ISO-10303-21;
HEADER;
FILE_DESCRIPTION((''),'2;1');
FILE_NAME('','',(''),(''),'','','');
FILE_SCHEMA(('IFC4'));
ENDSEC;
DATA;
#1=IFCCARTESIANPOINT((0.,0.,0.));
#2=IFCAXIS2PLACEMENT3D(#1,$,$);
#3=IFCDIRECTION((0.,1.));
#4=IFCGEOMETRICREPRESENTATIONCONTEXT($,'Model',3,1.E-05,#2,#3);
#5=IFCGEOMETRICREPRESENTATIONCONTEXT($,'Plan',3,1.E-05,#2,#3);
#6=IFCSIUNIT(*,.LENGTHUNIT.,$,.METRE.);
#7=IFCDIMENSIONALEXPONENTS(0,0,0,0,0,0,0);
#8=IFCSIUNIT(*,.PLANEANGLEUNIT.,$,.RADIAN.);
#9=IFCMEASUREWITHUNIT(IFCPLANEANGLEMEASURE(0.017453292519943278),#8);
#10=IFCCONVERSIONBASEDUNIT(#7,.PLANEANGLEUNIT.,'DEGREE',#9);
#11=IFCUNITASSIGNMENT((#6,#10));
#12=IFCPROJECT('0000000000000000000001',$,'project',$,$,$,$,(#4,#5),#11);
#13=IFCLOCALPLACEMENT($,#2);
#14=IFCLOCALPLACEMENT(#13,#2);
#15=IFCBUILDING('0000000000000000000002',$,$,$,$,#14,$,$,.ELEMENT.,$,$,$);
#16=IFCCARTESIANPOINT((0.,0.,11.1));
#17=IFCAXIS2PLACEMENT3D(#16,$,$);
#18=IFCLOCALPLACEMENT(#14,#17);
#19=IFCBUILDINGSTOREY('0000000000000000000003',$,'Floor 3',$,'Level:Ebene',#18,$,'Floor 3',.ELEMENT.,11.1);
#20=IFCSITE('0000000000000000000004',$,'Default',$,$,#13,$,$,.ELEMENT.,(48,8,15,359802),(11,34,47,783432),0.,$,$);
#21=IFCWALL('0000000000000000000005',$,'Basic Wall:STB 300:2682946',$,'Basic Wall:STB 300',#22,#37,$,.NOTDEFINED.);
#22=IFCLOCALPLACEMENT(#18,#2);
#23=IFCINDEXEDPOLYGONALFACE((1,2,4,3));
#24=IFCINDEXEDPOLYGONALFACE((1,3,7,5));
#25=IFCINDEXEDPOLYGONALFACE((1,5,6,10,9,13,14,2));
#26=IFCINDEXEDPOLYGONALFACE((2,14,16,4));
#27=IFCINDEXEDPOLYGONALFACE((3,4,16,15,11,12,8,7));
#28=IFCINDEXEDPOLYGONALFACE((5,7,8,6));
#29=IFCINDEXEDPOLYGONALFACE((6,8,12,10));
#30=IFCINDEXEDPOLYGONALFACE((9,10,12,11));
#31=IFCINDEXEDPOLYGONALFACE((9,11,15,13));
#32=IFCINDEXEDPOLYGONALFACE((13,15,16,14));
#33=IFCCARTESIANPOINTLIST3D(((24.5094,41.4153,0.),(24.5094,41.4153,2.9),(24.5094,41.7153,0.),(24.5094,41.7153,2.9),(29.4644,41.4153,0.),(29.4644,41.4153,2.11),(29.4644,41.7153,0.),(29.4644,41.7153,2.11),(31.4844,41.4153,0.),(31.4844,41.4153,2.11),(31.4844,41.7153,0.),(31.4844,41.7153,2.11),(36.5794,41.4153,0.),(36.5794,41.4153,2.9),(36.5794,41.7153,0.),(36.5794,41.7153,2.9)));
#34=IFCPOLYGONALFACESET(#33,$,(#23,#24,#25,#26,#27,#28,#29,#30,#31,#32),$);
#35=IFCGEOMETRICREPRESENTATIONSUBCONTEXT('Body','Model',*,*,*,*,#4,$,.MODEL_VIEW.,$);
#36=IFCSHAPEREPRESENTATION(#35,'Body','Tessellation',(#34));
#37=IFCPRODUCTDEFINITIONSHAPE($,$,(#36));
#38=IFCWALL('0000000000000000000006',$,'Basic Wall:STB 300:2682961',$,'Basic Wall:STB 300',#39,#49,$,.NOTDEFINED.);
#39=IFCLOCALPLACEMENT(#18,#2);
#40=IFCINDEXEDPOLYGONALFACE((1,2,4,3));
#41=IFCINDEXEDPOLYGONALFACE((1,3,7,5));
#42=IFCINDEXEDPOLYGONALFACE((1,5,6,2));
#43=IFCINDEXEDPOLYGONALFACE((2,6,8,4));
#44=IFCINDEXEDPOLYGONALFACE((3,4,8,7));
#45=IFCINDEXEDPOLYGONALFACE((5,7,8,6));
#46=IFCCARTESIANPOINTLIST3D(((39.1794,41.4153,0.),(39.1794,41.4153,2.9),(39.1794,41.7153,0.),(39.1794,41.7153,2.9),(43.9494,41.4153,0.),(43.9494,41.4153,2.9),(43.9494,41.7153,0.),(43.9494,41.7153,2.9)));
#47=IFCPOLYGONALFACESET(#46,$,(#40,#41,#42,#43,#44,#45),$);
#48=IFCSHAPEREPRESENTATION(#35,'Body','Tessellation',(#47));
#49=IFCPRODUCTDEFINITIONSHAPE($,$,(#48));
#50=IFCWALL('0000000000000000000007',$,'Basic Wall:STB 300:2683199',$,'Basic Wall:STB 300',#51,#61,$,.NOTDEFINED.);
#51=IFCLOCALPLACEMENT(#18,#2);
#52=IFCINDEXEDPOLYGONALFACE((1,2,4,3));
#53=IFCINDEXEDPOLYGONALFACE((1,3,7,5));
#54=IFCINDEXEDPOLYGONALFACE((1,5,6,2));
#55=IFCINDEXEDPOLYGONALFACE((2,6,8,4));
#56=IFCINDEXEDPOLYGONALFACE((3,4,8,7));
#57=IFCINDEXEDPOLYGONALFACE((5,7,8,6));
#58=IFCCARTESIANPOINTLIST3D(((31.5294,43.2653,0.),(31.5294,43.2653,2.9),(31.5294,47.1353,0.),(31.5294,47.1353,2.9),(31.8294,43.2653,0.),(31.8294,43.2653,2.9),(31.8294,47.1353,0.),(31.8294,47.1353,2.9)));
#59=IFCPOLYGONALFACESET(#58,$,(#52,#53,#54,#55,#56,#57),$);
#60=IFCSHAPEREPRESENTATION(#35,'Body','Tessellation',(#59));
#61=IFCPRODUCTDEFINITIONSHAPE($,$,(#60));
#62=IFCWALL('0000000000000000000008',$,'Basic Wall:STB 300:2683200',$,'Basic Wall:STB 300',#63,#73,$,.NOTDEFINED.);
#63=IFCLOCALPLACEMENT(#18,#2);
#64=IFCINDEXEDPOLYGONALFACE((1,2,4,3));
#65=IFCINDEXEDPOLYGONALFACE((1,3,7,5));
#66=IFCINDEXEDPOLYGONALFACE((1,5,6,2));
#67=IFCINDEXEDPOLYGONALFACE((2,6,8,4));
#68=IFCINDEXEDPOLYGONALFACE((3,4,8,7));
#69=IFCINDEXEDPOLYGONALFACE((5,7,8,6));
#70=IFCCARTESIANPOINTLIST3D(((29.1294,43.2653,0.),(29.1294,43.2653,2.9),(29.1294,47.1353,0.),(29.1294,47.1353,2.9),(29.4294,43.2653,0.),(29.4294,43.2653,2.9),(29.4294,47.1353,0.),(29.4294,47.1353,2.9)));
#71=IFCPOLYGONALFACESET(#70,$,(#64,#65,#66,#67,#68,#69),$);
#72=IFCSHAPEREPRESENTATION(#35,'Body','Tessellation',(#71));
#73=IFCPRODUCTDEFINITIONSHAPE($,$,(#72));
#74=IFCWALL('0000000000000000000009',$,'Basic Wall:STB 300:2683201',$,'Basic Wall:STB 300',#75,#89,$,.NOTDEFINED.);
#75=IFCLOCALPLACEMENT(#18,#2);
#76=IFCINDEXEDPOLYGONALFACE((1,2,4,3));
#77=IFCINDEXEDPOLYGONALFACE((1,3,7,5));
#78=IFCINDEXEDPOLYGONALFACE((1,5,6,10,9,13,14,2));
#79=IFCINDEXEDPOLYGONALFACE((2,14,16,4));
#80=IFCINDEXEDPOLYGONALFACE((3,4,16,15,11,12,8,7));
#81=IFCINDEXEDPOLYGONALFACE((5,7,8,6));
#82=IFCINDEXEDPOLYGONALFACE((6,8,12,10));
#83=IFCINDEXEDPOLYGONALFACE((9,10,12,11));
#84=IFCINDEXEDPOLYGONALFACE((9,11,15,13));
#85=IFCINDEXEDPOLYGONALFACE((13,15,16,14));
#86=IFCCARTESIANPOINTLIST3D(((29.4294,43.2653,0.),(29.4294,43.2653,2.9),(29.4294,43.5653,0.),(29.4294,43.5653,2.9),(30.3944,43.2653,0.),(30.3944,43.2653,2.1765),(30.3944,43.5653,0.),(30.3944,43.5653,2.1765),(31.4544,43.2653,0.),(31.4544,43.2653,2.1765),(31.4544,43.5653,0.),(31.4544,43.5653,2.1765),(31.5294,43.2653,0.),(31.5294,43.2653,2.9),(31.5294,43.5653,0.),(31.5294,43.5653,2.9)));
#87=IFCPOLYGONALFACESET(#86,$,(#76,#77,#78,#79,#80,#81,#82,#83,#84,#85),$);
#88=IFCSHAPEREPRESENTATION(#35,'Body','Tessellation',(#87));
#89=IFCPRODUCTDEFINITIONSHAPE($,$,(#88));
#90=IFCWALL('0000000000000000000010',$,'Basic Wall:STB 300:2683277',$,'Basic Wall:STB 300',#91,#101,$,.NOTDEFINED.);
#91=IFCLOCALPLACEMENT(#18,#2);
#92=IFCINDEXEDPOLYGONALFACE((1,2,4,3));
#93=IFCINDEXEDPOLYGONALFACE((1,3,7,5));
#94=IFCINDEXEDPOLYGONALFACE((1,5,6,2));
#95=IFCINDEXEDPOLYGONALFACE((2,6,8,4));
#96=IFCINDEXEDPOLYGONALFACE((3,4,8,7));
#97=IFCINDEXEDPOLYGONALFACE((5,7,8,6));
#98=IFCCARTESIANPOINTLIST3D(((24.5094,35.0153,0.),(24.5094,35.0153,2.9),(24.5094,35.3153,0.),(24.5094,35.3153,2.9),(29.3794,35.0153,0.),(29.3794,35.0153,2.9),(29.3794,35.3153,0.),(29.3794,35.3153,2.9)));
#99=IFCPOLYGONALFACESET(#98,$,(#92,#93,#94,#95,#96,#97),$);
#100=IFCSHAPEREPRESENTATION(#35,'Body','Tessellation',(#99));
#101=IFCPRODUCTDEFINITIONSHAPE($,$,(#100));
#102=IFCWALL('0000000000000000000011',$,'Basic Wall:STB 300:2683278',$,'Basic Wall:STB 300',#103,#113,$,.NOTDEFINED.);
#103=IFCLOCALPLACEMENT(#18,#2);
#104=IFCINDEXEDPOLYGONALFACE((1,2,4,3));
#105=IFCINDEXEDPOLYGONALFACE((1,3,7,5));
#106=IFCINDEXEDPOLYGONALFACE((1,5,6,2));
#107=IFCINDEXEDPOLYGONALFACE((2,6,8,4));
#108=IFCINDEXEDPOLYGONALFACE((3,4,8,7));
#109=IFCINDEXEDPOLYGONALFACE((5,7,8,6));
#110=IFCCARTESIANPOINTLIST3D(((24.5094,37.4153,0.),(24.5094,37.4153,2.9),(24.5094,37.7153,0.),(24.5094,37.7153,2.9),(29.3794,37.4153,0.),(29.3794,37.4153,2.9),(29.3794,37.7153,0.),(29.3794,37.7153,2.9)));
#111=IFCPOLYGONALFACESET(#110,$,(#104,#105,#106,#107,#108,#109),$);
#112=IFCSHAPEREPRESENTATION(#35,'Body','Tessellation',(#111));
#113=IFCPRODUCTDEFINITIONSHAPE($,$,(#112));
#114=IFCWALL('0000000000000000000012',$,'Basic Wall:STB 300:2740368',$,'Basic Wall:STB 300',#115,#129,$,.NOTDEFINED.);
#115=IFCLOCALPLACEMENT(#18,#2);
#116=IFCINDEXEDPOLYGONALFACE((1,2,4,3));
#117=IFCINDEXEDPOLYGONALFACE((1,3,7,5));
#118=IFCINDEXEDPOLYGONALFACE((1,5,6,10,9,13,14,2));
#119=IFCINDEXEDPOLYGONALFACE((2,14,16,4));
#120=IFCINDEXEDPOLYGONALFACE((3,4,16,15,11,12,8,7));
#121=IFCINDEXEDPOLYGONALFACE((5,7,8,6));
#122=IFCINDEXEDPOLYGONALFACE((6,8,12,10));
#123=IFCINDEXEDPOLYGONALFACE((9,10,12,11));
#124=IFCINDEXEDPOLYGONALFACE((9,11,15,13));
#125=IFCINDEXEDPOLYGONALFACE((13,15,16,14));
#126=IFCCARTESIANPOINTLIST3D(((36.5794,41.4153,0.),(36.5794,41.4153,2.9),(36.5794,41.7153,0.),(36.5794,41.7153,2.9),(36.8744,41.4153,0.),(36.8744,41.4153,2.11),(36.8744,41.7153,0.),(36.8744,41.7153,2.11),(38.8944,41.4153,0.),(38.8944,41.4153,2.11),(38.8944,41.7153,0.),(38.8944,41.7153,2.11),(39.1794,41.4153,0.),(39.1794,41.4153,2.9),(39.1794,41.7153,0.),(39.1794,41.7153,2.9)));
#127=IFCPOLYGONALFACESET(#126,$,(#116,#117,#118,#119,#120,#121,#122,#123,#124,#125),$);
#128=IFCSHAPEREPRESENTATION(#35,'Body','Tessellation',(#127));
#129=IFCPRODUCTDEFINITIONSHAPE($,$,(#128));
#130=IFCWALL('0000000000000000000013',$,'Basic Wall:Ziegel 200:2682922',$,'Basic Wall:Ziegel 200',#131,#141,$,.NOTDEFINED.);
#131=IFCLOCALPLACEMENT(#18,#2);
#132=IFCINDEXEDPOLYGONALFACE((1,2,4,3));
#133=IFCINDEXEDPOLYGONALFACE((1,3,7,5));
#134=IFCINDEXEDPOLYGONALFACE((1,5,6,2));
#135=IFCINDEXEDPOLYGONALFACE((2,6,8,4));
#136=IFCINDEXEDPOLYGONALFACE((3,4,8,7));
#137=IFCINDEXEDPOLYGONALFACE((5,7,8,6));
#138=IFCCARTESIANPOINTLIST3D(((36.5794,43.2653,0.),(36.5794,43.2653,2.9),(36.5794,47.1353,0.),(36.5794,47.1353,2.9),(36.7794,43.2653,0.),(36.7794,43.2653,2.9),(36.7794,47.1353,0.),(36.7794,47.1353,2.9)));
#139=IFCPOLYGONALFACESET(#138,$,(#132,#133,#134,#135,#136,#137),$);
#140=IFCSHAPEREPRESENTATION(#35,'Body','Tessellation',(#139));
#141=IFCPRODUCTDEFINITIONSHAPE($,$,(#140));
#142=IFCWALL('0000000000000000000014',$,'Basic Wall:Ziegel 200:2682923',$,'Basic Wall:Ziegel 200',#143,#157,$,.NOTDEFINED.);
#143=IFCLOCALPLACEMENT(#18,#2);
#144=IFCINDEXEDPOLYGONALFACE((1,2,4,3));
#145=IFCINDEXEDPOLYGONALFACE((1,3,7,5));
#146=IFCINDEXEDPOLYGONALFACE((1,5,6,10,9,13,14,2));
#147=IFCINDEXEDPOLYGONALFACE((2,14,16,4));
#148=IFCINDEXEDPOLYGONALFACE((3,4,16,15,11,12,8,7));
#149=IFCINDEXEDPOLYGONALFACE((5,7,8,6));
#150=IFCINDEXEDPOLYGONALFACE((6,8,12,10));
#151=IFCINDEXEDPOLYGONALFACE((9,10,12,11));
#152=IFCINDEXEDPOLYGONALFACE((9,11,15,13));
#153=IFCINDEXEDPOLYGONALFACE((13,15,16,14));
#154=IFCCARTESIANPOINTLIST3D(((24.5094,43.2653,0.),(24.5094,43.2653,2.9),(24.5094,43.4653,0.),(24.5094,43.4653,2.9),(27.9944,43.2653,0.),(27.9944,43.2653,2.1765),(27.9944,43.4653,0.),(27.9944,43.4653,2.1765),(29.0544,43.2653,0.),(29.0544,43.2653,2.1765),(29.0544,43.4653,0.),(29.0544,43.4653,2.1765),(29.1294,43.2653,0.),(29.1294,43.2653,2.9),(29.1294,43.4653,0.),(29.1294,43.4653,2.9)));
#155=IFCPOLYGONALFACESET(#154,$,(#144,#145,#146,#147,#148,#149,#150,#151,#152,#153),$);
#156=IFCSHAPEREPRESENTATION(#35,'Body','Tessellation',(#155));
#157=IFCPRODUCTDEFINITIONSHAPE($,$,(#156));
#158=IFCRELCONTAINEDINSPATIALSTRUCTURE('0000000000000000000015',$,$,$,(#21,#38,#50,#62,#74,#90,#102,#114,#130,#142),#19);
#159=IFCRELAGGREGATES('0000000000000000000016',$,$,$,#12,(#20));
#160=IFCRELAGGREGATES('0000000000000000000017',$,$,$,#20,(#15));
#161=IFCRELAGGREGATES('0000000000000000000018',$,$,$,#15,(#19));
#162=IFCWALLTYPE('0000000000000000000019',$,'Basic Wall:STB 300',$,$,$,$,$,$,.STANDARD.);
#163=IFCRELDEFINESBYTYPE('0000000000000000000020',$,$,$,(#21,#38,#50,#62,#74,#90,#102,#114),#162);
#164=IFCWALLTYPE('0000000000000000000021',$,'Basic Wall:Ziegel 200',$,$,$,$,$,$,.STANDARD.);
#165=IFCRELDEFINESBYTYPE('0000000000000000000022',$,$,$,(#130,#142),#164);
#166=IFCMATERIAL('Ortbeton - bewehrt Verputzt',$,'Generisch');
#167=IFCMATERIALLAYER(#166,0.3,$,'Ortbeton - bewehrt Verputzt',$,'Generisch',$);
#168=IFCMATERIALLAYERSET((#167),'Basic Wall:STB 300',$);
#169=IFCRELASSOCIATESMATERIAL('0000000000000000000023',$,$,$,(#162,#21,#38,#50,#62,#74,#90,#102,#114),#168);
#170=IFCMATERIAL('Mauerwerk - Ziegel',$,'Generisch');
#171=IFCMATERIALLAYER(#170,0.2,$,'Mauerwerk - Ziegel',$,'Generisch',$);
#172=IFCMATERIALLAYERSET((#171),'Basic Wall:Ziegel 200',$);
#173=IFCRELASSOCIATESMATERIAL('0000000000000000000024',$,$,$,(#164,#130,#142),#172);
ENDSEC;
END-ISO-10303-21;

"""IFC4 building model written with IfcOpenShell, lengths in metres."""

from ifc_helpers import new_model, entity, si_unit, converted_unit, direction, frame, frame_2d, origin, place, context, subcontext, project, spatial, rectangle, extrude, material, layer, layer_set, layer_usage, type_object, element, save


model = new_model("IFC4")

# Units and contexts
model_context = context("Model", 3, precision=1e-05, world=origin(), true_north=direction((0.0, 1.0)))
plan_context = context("Plan", 3, precision=1e-05, world=origin(), true_north=direction((0.0, 1.0)))
body_context = subcontext(model_context, "Body", "Model", "MODEL_VIEW")
ifc_project = project(units=[si_unit("LENGTHUNIT", "METRE"), converted_unit("PLANEANGLEUNIT", "DEGREE", entity("IfcPlaneAngleMeasure", 0.017453292519943278), si_unit("PLANEANGLEUNIT", "RADIAN"), dimensions=[0, 0, 0, 0, 0, 0, 0])], contexts=[model_context, plan_context])

# Site, building, storey
site_placement = place(None, origin())
site = spatial("IfcSite", under=ifc_project, at=site_placement, Name="Default", CompositionType="ELEMENT", RefLatitude=(48, 8, 15, 359802), RefLongitude=(11, 34, 47, 783432), RefElevation=0.0)
building_placement = place(site_placement, origin())
building = spatial("IfcBuilding", under=site, at=building_placement, CompositionType="ELEMENT")
storey_placement = place(building_placement, frame((0.0, 0.0, 11.1)))
storey = spatial("IfcBuildingStorey", under=building, at=storey_placement, Name="Floor 3", ObjectType="Level:Ebene", LongName="Floor 3", CompositionType="ELEMENT", Elevation=11.1)

# Wall, opening
ifc_material_1 = material(Name="Ortbeton - bewehrt Verputzt", Category="Generisch")
ifc_layer_1 = layer(ifc_material_1, 0.3, Name="Ortbeton - bewehrt Verputzt", Category="Generisch")
ifc_layer_set_1 = layer_set([ifc_layer_1], Name="Basic Wall:STB 300")
ifc_layer_usage_1 = layer_usage(ifc_layer_set_1, "AXIS2", "NEGATIVE", 0.15)
wall_type_1 = type_object("IfcWallType", Name="Basic Wall:STB 300", PredefinedType="STANDARD", material=ifc_layer_set_1)
wall_1_placement = place(storey_placement, frame((24.5094, 41.5653, 0.0)))
wall_1 = element("IfcWall", 1, at=wall_1_placement, inside=storey, type_object=wall_type_1, material=ifc_layer_usage_1, Name="Basic Wall:STB 300:2682946", ObjectType="Basic Wall:STB 300", PredefinedType="NOTDEFINED", context=body_context, shape_type="SweptSolid", body=[
    extrude(rectangle(XDim=12.07, YDim=0.3, at=frame_2d((6.035, 0.0), x_axis=(-1.0, 0.0))), origin(), (0.0, 0.0, 1.0), 2.9),
])
opening_1_placement = place(wall_1_placement, frame((6.975, 0.15, 0.0)))
element("IfcOpeningElement", 2, at=opening_1_placement, cuts=wall_1, PredefinedType="OPENING", context=body_context, shape_type="SweptSolid", body=[
    extrude(rectangle(XDim=2.11, YDim=2.02, at=frame_2d((1.055, 1.01), x_axis=(1.0, 0.0))), frame((0.0, 0.0, 0.0), z_axis=(0.0, -1.0, 0.0), x_axis=(0.0, 0.0, 1.0)), (0.0, 0.0, 1.0), 0.3),
])

# Walls
wall_2_placement = place(storey_placement, frame((39.1794, 41.5653, 0.0)))
element("IfcWall", 3, at=wall_2_placement, inside=storey, type_object=wall_type_1, material=ifc_layer_usage_1, Name="Basic Wall:STB 300:2682961", ObjectType="Basic Wall:STB 300", PredefinedType="NOTDEFINED", context=body_context, shape_type="SweptSolid", body=[
    extrude(rectangle(XDim=4.77, YDim=0.3, at=frame_2d((2.385, 0.0), x_axis=(-1.0, 0.0))), origin(), (0.0, 0.0, 1.0), 2.9),
])
wall_3_placement = place(storey_placement, frame((31.6794, 47.1353, 0.0), z_axis=(0.0, 0.0, 1.0), x_axis=(0.0, -1.0, 0.0)))
element("IfcWall", 4, at=wall_3_placement, inside=storey, type_object=wall_type_1, material=ifc_layer_usage_1, Name="Basic Wall:STB 300:2683199", ObjectType="Basic Wall:STB 300", PredefinedType="NOTDEFINED", context=body_context, shape_type="SweptSolid", body=[
    extrude(rectangle(XDim=3.87, YDim=0.3, at=frame_2d((1.935, 0.0), x_axis=(-1.0, 0.0))), origin(), (0.0, 0.0, 1.0), 2.9),
])
wall_4_placement = place(storey_placement, frame((29.2794, 43.2653, 0.0), z_axis=(0.0, 0.0, 1.0), x_axis=(0.0, 1.0, 0.0)))
element("IfcWall", 5, at=wall_4_placement, inside=storey, type_object=wall_type_1, material=ifc_layer_usage_1, Name="Basic Wall:STB 300:2683200", ObjectType="Basic Wall:STB 300", PredefinedType="NOTDEFINED", context=body_context, shape_type="SweptSolid", body=[
    extrude(rectangle(XDim=3.87, YDim=0.3, at=frame_2d((1.935, 0.0), x_axis=(-1.0, 0.0))), origin(), (0.0, 0.0, 1.0), 2.9),
])

# Wall, opening
wall_5_placement = place(storey_placement, frame((29.4294, 43.4153, 0.0)))
wall_5 = element("IfcWall", 6, at=wall_5_placement, inside=storey, type_object=wall_type_1, material=ifc_layer_usage_1, Name="Basic Wall:STB 300:2683201", ObjectType="Basic Wall:STB 300", PredefinedType="NOTDEFINED", context=body_context, shape_type="SweptSolid", body=[
    extrude(rectangle(XDim=2.1, YDim=0.3, at=frame_2d((1.05, 0.0), x_axis=(1.0, 0.0))), origin(), (0.0, 0.0, 1.0), 2.9),
])
opening_2_placement = place(wall_5_placement, frame((0.965, -0.15, 0.0)))
element("IfcOpeningElement", 7, at=opening_2_placement, cuts=wall_5, PredefinedType="OPENING", context=body_context, shape_type="SweptSolid", body=[
    extrude(rectangle(XDim=2.1765, YDim=1.06, at=frame_2d((1.0882, 0.53), x_axis=(1.0, 0.0))), frame((0.0, 0.0, 0.0), z_axis=(0.0, 1.0, 0.0), x_axis=(0.0, 0.0, 1.0)), (0.0, 0.0, 1.0), 0.3),
])

# Walls
wall_6_placement = place(storey_placement, frame((29.3794, 35.1653, 0.0), z_axis=(0.0, 0.0, 1.0), x_axis=(-1.0, 0.0, 0.0)))
element("IfcWall", 8, at=wall_6_placement, inside=storey, type_object=wall_type_1, material=ifc_layer_usage_1, Name="Basic Wall:STB 300:2683277", ObjectType="Basic Wall:STB 300", PredefinedType="NOTDEFINED", context=body_context, shape_type="SweptSolid", body=[
    extrude(rectangle(XDim=4.87, YDim=0.3, at=frame_2d((2.435, 0.0), x_axis=(-1.0, 0.0))), origin(), (0.0, 0.0, 1.0), 2.9),
])
wall_7_placement = place(storey_placement, frame((29.3794, 37.5653, 0.0), z_axis=(0.0, 0.0, 1.0), x_axis=(-1.0, 0.0, 0.0)))
element("IfcWall", 9, at=wall_7_placement, inside=storey, type_object=wall_type_1, material=ifc_layer_usage_1, Name="Basic Wall:STB 300:2683278", ObjectType="Basic Wall:STB 300", PredefinedType="NOTDEFINED", context=body_context, shape_type="SweptSolid", body=[
    extrude(rectangle(XDim=4.87, YDim=0.3, at=frame_2d((2.435, 0.0), x_axis=(-1.0, 0.0))), origin(), (0.0, 0.0, 1.0), 2.9),
])

# Wall, opening
wall_8_placement = place(storey_placement, frame((36.5794, 41.5653, 0.0)))
wall_8 = element("IfcWall", 10, at=wall_8_placement, inside=storey, type_object=wall_type_1, material=ifc_layer_usage_1, Name="Basic Wall:STB 300:2740368", ObjectType="Basic Wall:STB 300", PredefinedType="NOTDEFINED", context=body_context, shape_type="SweptSolid", body=[
    extrude(rectangle(XDim=2.6, YDim=0.3, at=frame_2d((1.3, 0.0), x_axis=(-1.0, 0.0))), origin(), (0.0, 0.0, 1.0), 2.9),
])
opening_3_placement = place(wall_8_placement, frame((2.315, 0.15, 0.0)))
element("IfcOpeningElement", 11, at=opening_3_placement, cuts=wall_8, PredefinedType="OPENING", context=body_context, shape_type="SweptSolid", body=[
    extrude(rectangle(XDim=2.11, YDim=2.02, at=frame_2d((1.055, 1.01), x_axis=(1.0, 0.0))), frame((0.0, 0.0, 0.0), z_axis=(0.0, -1.0, 0.0), x_axis=(0.0, 0.0, 1.0)), (0.0, 0.0, 1.0), 0.3),
])

# Wall
ifc_material_2 = material(Name="Mauerwerk - Ziegel", Category="Generisch")
ifc_layer_2 = layer(ifc_material_2, 0.2, Name="Mauerwerk - Ziegel", Category="Generisch")
ifc_layer_set_2 = layer_set([ifc_layer_2], Name="Basic Wall:Ziegel 200")
ifc_layer_usage_2 = layer_usage(ifc_layer_set_2, "AXIS2", "NEGATIVE", 0.1)
wall_type_2 = type_object("IfcWallType", Name="Basic Wall:Ziegel 200", PredefinedType="STANDARD", material=ifc_layer_set_2)
wall_9_placement = place(storey_placement, frame((36.6794, 47.1353, 0.0), z_axis=(0.0, 0.0, 1.0), x_axis=(0.0, -1.0, 0.0)))
element("IfcWall", 12, at=wall_9_placement, inside=storey, type_object=wall_type_2, material=ifc_layer_usage_2, Name="Basic Wall:Ziegel 200:2682922", ObjectType="Basic Wall:Ziegel 200", PredefinedType="NOTDEFINED", context=body_context, shape_type="SweptSolid", body=[
    extrude(rectangle(XDim=3.87, YDim=0.2, at=frame_2d((1.935, 0.0), x_axis=(-1.0, 0.0))), origin(), (0.0, 0.0, 1.0), 2.9),
])

# Wall, opening
wall_10_placement = place(storey_placement, frame((29.1294, 43.3653, 0.0), z_axis=(0.0, 0.0, 1.0), x_axis=(-1.0, 0.0, 0.0)))
wall_10 = element("IfcWall", 13, at=wall_10_placement, inside=storey, type_object=wall_type_2, material=ifc_layer_usage_2, Name="Basic Wall:Ziegel 200:2682923", ObjectType="Basic Wall:Ziegel 200", PredefinedType="NOTDEFINED", context=body_context, shape_type="SweptSolid", body=[
    extrude(rectangle(XDim=4.62, YDim=0.2, at=frame_2d((2.31, 0.0), x_axis=(-1.0, 0.0))), origin(), (0.0, 0.0, 1.0), 2.9),
])
opening_4_placement = place(wall_10_placement, frame((0.075, -0.1, 0.0)))
element("IfcOpeningElement", 14, at=opening_4_placement, cuts=wall_10, PredefinedType="OPENING", context=body_context, shape_type="SweptSolid", body=[
    extrude(rectangle(XDim=2.1765, YDim=1.06, at=frame_2d((1.0882, 0.53), x_axis=(1.0, 0.0))), frame((0.0, 0.0, 0.0), z_axis=(0.0, 1.0, 0.0), x_axis=(0.0, 0.0, 1.0)), (0.0, 0.0, 1.0), 0.2),
])

save(model, "model.ifc")
